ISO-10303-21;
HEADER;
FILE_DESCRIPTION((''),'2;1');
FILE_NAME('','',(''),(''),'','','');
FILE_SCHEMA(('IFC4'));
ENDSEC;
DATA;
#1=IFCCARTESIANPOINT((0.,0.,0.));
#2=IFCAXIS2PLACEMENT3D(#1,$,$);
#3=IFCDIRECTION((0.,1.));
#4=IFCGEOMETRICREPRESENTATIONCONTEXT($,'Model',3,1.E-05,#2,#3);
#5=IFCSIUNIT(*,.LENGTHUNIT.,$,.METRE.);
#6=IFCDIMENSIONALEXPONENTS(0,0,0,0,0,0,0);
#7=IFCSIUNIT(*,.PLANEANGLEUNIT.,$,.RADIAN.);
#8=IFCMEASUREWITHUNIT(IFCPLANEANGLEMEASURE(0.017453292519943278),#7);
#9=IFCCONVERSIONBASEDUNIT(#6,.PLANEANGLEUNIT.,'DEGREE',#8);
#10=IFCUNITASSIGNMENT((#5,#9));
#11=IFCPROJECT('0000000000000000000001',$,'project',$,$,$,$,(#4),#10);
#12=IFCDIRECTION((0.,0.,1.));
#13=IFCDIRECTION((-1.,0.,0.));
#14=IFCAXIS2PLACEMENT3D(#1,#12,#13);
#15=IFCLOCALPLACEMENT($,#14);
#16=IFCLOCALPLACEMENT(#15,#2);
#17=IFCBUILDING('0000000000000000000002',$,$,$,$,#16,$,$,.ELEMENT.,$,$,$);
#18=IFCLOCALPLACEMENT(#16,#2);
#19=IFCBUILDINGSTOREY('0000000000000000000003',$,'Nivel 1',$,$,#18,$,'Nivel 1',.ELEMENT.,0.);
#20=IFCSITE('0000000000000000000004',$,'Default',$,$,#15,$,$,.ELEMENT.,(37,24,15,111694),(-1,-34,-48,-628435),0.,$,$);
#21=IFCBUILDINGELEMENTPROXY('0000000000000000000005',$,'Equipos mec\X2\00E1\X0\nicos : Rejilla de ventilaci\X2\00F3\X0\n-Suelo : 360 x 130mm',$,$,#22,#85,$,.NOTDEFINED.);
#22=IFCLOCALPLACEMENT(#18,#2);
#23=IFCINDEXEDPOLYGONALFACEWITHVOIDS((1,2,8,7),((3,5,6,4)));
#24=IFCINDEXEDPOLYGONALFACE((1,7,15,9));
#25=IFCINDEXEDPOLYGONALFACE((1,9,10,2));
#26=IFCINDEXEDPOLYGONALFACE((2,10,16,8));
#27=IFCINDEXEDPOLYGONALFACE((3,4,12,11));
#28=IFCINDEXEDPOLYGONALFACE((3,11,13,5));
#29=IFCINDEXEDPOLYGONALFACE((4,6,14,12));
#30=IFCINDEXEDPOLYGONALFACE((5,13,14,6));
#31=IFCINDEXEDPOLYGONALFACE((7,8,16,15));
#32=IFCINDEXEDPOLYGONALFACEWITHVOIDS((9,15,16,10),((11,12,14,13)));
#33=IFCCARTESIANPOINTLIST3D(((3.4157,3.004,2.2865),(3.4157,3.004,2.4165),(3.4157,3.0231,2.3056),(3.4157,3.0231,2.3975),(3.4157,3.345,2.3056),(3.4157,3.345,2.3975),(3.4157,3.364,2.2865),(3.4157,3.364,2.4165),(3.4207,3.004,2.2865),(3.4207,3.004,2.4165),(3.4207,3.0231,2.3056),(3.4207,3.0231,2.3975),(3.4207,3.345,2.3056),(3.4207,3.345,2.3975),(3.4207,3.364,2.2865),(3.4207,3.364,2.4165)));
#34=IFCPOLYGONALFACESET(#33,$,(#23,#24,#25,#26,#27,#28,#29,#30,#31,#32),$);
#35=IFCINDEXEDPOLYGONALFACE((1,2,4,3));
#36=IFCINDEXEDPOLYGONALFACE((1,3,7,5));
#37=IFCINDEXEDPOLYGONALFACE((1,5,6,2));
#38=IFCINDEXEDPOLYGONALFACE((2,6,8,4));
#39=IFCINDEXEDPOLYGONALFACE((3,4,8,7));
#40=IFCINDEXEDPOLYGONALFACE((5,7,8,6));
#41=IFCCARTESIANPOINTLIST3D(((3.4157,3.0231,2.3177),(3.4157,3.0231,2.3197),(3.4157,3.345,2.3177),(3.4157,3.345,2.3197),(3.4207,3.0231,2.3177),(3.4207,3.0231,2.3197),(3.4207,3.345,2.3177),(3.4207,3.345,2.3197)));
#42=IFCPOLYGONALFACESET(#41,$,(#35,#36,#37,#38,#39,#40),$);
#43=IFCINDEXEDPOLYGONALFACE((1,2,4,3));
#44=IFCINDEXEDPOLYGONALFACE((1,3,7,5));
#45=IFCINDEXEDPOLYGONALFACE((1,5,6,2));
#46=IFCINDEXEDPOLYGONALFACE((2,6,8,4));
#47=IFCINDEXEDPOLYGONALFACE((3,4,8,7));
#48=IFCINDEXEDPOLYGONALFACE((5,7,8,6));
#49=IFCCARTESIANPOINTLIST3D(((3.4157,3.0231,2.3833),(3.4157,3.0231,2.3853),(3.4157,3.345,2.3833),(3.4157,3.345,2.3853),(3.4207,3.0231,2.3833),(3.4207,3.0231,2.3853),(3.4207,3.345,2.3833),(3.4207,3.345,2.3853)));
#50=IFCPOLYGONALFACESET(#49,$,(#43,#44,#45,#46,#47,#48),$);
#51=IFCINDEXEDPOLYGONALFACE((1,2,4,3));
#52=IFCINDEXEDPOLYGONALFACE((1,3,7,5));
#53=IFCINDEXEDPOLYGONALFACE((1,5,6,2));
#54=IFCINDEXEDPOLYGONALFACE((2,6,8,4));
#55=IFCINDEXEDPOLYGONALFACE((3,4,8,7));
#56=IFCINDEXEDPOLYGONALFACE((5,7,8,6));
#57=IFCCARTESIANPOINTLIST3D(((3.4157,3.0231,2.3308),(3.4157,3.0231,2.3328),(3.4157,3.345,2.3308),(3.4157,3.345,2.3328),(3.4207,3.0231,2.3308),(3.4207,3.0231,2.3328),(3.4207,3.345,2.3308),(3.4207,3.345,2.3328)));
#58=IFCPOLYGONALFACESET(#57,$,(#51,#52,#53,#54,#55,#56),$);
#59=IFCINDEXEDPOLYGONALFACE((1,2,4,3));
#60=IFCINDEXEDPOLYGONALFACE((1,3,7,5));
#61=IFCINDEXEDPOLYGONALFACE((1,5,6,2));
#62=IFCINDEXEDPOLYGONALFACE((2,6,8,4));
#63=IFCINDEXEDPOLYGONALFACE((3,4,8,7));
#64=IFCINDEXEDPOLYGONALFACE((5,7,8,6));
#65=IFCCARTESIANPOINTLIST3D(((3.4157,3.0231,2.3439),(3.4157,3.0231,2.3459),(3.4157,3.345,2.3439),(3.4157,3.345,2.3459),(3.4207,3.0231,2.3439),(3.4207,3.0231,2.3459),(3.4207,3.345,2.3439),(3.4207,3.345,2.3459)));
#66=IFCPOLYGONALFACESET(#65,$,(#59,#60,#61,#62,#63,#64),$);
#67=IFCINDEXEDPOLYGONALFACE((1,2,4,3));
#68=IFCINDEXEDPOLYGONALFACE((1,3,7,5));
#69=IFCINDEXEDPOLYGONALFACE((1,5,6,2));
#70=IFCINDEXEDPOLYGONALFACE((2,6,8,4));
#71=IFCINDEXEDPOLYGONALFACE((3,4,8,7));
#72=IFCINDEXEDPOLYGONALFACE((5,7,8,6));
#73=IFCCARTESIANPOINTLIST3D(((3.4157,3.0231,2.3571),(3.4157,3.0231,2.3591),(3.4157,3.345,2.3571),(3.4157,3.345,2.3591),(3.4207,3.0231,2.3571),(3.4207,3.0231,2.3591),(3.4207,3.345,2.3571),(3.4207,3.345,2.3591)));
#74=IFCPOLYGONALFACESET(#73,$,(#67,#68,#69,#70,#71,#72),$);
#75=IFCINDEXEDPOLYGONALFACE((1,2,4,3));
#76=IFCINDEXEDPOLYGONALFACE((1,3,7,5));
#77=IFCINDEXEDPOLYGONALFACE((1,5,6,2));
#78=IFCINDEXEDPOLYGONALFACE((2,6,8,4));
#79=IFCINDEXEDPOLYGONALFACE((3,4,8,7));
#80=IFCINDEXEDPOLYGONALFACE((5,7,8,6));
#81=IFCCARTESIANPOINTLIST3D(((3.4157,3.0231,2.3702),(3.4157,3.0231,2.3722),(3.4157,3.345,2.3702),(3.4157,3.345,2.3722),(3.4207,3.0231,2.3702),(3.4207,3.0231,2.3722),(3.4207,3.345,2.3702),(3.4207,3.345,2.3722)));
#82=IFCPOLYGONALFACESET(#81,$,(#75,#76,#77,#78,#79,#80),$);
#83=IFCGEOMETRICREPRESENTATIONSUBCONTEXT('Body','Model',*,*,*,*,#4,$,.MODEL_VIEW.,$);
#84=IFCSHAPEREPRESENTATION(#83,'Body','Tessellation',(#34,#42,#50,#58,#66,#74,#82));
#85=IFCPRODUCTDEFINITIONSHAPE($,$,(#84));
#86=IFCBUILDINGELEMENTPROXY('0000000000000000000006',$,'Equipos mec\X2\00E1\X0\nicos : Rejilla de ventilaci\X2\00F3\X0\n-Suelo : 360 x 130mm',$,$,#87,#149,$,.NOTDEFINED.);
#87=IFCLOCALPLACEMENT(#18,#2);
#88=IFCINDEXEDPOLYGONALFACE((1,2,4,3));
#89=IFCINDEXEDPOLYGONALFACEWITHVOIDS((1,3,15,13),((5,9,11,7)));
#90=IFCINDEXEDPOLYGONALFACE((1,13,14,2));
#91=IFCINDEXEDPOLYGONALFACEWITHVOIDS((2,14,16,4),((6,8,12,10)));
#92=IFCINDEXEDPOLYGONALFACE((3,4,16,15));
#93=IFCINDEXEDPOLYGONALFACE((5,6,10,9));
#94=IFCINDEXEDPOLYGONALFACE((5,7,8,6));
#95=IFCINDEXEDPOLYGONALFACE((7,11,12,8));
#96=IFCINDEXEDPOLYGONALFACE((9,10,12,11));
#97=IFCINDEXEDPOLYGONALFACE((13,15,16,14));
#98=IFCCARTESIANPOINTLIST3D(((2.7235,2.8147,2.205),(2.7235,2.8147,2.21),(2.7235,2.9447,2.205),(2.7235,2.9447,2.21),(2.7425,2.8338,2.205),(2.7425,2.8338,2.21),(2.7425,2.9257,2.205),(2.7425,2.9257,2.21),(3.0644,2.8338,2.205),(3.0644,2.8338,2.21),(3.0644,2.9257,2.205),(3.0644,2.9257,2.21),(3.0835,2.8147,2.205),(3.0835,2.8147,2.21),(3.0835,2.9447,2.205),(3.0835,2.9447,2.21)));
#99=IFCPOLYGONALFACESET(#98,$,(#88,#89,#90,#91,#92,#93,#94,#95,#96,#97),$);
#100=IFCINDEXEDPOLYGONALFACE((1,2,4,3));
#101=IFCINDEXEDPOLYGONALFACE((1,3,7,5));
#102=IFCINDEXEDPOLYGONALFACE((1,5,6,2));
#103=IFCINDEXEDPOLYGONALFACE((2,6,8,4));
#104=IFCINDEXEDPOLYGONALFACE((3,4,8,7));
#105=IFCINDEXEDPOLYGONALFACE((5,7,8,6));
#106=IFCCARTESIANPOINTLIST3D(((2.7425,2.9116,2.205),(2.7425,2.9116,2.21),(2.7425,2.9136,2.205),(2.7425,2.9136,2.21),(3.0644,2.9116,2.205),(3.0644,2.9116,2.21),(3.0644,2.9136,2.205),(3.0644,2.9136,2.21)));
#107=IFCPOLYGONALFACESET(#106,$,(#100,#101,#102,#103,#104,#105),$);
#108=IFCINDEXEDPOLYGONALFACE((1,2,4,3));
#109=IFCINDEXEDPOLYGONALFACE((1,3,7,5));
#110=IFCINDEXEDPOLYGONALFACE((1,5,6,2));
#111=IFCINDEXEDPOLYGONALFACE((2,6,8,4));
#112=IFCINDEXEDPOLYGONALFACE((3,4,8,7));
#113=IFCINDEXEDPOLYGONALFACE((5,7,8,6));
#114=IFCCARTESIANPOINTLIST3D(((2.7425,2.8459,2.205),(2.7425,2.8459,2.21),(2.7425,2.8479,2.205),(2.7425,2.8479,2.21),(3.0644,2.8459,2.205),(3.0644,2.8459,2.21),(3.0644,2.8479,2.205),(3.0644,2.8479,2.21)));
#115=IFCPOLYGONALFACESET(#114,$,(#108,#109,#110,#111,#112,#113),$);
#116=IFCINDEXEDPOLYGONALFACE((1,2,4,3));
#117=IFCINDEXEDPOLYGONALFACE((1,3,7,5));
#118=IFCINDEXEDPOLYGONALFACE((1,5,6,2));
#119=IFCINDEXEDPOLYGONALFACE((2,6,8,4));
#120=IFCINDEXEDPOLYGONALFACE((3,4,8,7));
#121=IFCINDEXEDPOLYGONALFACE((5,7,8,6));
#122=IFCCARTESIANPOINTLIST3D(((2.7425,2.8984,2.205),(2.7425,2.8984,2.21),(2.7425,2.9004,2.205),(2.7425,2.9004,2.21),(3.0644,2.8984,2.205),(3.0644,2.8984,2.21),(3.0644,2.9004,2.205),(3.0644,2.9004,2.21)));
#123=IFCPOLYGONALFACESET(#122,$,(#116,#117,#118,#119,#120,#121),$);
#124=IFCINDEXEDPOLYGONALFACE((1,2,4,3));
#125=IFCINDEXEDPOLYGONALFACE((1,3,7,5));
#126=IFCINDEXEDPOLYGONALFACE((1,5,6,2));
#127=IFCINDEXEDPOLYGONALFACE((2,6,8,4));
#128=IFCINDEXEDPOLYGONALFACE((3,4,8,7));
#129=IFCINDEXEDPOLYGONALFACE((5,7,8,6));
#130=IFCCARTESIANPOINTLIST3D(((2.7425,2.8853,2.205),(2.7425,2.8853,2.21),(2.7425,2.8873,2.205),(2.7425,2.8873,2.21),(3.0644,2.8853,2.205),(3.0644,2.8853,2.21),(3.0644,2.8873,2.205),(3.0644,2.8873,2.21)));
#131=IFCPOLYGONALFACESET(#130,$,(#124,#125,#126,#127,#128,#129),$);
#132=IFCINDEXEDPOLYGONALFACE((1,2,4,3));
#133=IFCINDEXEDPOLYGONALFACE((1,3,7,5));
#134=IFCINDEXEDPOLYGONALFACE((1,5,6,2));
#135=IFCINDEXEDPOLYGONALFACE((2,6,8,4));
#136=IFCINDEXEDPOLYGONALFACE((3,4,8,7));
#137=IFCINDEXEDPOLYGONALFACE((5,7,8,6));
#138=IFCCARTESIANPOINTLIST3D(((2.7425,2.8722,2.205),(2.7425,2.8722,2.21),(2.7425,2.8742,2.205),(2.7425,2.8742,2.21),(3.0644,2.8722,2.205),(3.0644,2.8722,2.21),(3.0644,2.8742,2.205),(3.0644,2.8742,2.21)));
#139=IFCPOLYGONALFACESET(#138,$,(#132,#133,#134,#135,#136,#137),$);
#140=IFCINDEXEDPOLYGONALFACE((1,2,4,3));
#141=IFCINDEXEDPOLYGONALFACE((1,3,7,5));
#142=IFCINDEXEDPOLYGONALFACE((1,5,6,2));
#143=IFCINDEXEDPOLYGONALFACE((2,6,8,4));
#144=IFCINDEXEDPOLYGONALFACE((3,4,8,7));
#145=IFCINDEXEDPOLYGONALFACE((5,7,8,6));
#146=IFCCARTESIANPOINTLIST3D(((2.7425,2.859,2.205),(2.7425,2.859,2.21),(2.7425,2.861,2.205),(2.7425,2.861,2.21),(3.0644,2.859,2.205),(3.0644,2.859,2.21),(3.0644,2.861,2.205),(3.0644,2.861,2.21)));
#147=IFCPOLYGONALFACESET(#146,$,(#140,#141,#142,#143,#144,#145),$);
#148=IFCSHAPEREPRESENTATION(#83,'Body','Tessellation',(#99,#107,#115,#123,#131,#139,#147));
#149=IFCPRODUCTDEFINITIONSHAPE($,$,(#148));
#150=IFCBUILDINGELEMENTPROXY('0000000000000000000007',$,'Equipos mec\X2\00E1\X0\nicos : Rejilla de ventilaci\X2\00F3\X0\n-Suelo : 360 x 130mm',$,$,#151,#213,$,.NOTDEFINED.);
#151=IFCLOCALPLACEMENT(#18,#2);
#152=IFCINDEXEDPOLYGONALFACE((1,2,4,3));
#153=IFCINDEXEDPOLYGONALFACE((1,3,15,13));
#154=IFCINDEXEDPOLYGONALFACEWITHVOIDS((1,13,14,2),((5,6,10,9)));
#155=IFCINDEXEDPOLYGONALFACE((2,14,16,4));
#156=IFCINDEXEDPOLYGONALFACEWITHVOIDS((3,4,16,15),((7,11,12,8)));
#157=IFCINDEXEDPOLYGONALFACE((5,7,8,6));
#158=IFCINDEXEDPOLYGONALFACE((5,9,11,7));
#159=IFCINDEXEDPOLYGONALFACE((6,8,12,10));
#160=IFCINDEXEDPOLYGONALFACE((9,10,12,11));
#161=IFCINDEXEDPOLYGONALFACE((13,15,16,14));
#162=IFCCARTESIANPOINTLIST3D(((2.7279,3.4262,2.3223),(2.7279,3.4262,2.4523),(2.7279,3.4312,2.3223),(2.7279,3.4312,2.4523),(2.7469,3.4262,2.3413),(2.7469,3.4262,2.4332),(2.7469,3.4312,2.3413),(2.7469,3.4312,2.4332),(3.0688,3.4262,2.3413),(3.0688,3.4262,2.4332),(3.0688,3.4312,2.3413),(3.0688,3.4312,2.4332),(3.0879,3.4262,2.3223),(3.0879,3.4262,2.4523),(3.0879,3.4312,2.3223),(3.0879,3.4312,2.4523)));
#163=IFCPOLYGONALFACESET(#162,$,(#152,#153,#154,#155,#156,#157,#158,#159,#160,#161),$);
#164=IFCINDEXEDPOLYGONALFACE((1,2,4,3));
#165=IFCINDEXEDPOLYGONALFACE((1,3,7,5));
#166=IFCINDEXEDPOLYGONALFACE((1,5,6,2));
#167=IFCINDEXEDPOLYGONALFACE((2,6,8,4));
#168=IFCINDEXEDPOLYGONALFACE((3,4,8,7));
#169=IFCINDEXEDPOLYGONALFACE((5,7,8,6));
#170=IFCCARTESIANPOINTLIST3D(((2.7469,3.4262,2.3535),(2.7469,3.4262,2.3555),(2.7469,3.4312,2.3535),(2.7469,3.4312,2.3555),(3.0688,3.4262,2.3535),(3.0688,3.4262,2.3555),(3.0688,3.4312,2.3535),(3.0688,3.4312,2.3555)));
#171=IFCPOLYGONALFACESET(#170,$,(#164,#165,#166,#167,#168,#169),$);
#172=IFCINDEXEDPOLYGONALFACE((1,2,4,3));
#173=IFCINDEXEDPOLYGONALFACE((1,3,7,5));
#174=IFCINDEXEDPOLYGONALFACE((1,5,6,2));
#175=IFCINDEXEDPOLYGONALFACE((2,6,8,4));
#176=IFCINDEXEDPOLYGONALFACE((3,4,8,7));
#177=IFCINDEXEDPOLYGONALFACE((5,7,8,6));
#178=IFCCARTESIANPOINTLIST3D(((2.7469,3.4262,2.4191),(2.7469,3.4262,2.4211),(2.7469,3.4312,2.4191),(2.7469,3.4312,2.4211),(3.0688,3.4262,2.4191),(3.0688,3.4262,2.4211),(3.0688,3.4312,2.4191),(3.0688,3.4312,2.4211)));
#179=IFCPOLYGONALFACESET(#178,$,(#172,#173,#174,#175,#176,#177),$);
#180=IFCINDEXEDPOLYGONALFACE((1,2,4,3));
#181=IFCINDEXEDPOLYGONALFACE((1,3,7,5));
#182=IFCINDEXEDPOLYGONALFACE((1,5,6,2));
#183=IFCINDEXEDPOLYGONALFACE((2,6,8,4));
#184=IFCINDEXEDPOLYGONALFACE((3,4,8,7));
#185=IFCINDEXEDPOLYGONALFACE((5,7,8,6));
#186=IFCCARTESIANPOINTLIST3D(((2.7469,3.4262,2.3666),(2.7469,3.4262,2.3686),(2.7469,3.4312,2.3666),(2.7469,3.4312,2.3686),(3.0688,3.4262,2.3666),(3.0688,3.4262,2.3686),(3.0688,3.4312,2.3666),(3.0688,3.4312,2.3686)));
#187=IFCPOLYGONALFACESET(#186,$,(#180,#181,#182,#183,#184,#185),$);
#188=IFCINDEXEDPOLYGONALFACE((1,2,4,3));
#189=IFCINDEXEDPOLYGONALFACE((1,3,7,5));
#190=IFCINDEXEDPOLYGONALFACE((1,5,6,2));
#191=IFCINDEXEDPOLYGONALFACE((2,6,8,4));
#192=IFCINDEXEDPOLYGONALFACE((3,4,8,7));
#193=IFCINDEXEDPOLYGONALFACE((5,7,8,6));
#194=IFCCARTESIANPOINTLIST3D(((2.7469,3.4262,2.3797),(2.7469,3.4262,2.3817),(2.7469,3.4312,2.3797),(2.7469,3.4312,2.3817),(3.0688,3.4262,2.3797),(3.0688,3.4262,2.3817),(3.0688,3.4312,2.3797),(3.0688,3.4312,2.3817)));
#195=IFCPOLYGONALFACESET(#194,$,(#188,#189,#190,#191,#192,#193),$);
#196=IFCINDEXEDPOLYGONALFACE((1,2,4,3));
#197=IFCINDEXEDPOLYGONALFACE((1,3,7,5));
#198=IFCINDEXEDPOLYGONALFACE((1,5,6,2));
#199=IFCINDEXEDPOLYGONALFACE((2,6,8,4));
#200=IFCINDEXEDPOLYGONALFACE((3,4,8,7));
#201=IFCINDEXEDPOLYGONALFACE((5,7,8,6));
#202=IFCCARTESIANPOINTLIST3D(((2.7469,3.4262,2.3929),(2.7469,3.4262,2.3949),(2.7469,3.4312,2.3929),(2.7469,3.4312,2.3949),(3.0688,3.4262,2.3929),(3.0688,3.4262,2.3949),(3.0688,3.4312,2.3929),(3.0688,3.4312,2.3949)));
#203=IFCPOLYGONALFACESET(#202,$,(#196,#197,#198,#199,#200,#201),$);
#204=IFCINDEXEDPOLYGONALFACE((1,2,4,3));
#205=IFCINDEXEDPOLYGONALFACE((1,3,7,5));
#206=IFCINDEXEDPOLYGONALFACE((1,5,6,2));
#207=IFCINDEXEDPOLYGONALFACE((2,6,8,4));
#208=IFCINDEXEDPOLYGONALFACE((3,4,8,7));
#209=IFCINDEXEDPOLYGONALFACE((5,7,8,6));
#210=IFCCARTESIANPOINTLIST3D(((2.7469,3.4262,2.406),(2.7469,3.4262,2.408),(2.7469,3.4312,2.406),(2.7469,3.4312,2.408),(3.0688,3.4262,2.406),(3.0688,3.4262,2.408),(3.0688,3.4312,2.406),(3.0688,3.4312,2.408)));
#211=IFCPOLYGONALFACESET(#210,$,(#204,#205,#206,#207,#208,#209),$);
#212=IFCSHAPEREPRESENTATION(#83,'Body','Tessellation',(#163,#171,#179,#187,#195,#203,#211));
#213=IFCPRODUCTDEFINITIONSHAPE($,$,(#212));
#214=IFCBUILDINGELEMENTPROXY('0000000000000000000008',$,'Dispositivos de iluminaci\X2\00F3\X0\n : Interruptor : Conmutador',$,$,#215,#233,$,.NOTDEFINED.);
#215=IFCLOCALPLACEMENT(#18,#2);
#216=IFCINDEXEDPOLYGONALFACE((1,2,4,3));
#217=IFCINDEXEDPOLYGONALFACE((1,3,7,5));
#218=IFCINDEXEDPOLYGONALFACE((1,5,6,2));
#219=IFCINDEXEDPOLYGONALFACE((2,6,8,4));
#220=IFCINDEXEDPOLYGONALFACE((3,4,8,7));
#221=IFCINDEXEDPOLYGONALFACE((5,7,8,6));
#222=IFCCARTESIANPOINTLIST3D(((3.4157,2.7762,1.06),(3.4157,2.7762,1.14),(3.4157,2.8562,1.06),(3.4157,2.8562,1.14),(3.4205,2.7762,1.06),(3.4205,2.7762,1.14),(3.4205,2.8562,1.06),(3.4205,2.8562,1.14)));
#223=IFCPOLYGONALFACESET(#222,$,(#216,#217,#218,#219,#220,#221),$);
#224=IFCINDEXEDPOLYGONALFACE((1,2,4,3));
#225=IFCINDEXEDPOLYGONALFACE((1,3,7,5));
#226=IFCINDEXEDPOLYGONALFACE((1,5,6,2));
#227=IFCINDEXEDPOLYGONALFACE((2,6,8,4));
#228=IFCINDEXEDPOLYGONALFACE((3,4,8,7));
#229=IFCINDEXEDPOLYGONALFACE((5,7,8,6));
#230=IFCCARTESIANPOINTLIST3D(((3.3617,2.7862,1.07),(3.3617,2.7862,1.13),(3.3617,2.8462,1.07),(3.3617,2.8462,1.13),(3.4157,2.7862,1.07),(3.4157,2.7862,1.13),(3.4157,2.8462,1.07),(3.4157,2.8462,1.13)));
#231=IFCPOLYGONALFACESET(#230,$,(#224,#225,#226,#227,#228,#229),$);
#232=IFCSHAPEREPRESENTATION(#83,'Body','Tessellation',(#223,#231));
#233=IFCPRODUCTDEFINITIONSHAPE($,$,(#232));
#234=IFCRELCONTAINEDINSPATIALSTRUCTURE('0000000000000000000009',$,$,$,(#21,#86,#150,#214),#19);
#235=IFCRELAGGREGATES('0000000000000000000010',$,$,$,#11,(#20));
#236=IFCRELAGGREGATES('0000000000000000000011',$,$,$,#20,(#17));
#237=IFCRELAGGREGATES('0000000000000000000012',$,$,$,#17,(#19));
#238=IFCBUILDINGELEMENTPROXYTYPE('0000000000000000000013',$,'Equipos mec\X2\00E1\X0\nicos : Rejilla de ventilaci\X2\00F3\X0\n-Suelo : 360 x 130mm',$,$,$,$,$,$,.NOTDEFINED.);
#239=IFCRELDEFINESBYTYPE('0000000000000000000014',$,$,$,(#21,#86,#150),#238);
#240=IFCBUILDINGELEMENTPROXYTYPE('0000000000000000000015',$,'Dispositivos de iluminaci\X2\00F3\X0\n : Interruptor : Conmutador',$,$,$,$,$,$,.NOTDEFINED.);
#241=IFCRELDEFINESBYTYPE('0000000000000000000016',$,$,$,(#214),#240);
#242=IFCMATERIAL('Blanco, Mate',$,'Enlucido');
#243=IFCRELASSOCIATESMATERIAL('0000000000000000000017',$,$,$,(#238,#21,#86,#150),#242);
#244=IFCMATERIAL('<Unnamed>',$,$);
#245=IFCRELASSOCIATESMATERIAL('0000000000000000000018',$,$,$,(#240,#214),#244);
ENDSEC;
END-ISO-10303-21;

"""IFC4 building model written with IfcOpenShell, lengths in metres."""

from ifc_helpers import new_model, entity, si_unit, converted_unit, direction, frame, origin, place, context, subcontext, project, spatial, indexed_curve, outline, extrude, source, transform, mapped, material, type_object, type_shapes, element, save


model = new_model("IFC4")

# Units and contexts
model_context = context("Model", 3, precision=1e-05, world=origin(), true_north=direction((0.0, 1.0)))
body_context = subcontext(model_context, "Body", "Model", "MODEL_VIEW")
ifc_project = project(units=[si_unit("LENGTHUNIT", "METRE"), converted_unit("PLANEANGLEUNIT", "DEGREE", entity("IfcPlaneAngleMeasure", 0.017453292519943278), si_unit("PLANEANGLEUNIT", "RADIAN"), dimensions=[0, 0, 0, 0, 0, 0, 0])], contexts=[model_context])

# Site, building, storey
site_placement = place(None, frame((0.0, 0.0, 0.0), z_axis=(0.0, 0.0, 1.0), x_axis=(-1.0, 0.0, 0.0)))
site = spatial("IfcSite", under=ifc_project, at=site_placement, Name="Default", CompositionType="ELEMENT", RefLatitude=(37, 24, 15, 111694), RefLongitude=(-1, -34, -48, -628435), RefElevation=0.0)
building_placement = place(site_placement, origin())
building = spatial("IfcBuilding", under=site, at=building_placement, CompositionType="ELEMENT")
storey_placement = place(building_placement, origin())
storey = spatial("IfcBuildingStorey", under=building, at=storey_placement, Name="Nivel 1", LongName="Nivel 1", CompositionType="ELEMENT", Elevation=0.0)

# Shared definitions
ifc_material_1 = material(Name="Blanco, Mate", Category="Enlucido")

# Shared definitions
ifc_material_2 = material(Name="<Unnamed>")

# Building element proxies
building_element_proxy_type_1 = type_object("IfcBuildingElementProxyType", Name="Equipos mecánicos : Rejilla de ventilación-Suelo : 360 x 130mm", PredefinedType="NOTDEFINED", material=ifc_material_1)
shared_shape_1 = source(origin(), body_context, "Body", "SweptSolid", [
    extrude(outline(indexed_curve([(-0.065, -0.18), (0.065, -0.18), (0.065, 0.18), (-0.065, 0.18), (-0.065, -0.18)], self_intersect=False), holes=[indexed_curve([(-0.0459, -0.1609), (-0.0459, 0.1609), (0.046, 0.1609), (0.046, -0.1609), (-0.0459, -0.1609)], self_intersect=False)]), frame((-0.0022, 0.0015, 0.0), z_axis=(0.0, 0.0, 1.0), x_axis=(0.0, 1.0, 0.0)), (0.0, 0.0, 1.0), 0.005),
    extrude(outline(indexed_curve([(-0.001, -0.1609), (0.001, -0.1609), (0.001, 0.1609), (-0.001, 0.1609), (-0.001, -0.1609)], self_intersect=False)), frame((-0.0022, -0.0313, 0.0), z_axis=(0.0, 0.0, 1.0), x_axis=(0.0, 1.0, 0.0)), (0.0, 0.0, 1.0), 0.005),
    extrude(outline(indexed_curve([(-0.001, -0.1609), (0.001, -0.1609), (0.001, 0.1609), (-0.001, 0.1609), (-0.001, -0.1609)], self_intersect=False)), frame((-0.0022, 0.0343, 0.0), z_axis=(0.0, 0.0, 1.0), x_axis=(0.0, 1.0, 0.0)), (0.0, 0.0, 1.0), 0.005),
    extrude(outline(indexed_curve([(-0.001, -0.1609), (0.001, -0.1609), (0.001, 0.1609), (-0.001, 0.1609), (-0.001, -0.1609)], self_intersect=False)), frame((-0.0022, -0.0182, 0.0), z_axis=(0.0, 0.0, 1.0), x_axis=(0.0, 1.0, 0.0)), (0.0, 0.0, 1.0), 0.005),
    extrude(outline(indexed_curve([(-0.001, -0.1609), (0.001, -0.1609), (0.001, 0.1609), (-0.001, 0.1609), (-0.001, -0.1609)], self_intersect=False)), frame((-0.0022, -0.0051, 0.0), z_axis=(0.0, 0.0, 1.0), x_axis=(0.0, 1.0, 0.0)), (0.0, 0.0, 1.0), 0.005),
    extrude(outline(indexed_curve([(-0.001, -0.1609), (0.001, -0.1609), (0.001, 0.1609), (-0.001, 0.1609), (-0.001, -0.1609)], self_intersect=False)), frame((-0.0022, 0.0081, 0.0), z_axis=(0.0, 0.0, 1.0), x_axis=(0.0, 1.0, 0.0)), (0.0, 0.0, 1.0), 0.005),
    extrude(outline(indexed_curve([(-0.001, -0.1609), (0.001, -0.1609), (0.001, 0.1609), (-0.001, 0.1609), (-0.001, -0.1609)], self_intersect=False)), frame((-0.0022, 0.0212, 0.0), z_axis=(0.0, 0.0, 1.0), x_axis=(0.0, 1.0, 0.0)), (0.0, 0.0, 1.0), 0.005),
])
type_shapes(building_element_proxy_type_1, [shared_shape_1])
for number, where, z_axis, x_axis, name in (
    (1, (3.4157, 3.1862, 2.35), (1.0, 0.0, 0.0), (0.0, 1.0, 0.0), "Equipos mecánicos : Rejilla de ventilación-Suelo : 360 x 130mm"),
    (2, (2.9057, 2.8812, 2.21), (0.0, 0.0, -1.0), (1.0, 0.0, 0.0), "Equipos mecánicos : Rejilla de ventilación-Suelo : 360 x 130mm"),
    (3, (2.9057, 3.4262, 2.3858), (0.0, 1.0, 0.0), (-1.0, 0.0, 0.0), "Equipos mecánicos : Rejilla de ventilación-Suelo : 360 x 130mm"),
):
    element("IfcBuildingElementProxy", number, at=place(storey_placement, frame(where, z_axis=z_axis, x_axis=x_axis)), inside=storey, type_object=building_element_proxy_type_1, material=ifc_material_1, Name=name, PredefinedType="NOTDEFINED", context=body_context, shape_type="MappedRepresentation", body=[
        mapped(shared_shape_1, transform((0.0, 0.0, 0.0), scale=1.0)),
    ])
building_element_proxy_type_2 = type_object("IfcBuildingElementProxyType", Name="Dispositivos de iluminación : Interruptor : Conmutador", PredefinedType="NOTDEFINED", material=ifc_material_2)
shared_shape_2 = source(origin(), body_context, "Body", "SweptSolid", [
    extrude(outline(indexed_curve([(-0.04, -0.04), (0.04, -0.04), (0.04, 0.04), (-0.04, 0.04), (-0.04, -0.04)], self_intersect=False)), frame((0.0, 0.0, 0.0), z_axis=(0.0, 0.0, 1.0), x_axis=(0.0, -1.0, 0.0)), (0.0, 0.0, 1.0), 0.0048),
    extrude(outline(indexed_curve([(-0.03, -0.03), (0.03, -0.03), (0.03, 0.03), (-0.03, 0.03), (-0.03, -0.03)], self_intersect=False)), frame((0.0, 0.0, -0.054), z_axis=(0.0, 0.0, 1.0), x_axis=(-1.0, 0.0, 0.0)), (0.0, 0.0, 1.0), 0.054),
])
type_shapes(building_element_proxy_type_2, [shared_shape_2])
for number, where, z_axis, x_axis, name in (
    (4, (3.4157, 2.8162, 1.1), (1.0, 0.0, 0.0), (0.0, 1.0, 0.0), "Dispositivos de iluminación : Interruptor : Conmutador"),
):
    element("IfcBuildingElementProxy", number, at=place(storey_placement, frame(where, z_axis=z_axis, x_axis=x_axis)), inside=storey, type_object=building_element_proxy_type_2, material=ifc_material_2, Name=name, PredefinedType="NOTDEFINED", context=body_context, shape_type="MappedRepresentation", body=[
        mapped(shared_shape_2, transform((0.0, 0.0, 0.0), scale=1.0)),
    ])

save(model, "model.ifc")
